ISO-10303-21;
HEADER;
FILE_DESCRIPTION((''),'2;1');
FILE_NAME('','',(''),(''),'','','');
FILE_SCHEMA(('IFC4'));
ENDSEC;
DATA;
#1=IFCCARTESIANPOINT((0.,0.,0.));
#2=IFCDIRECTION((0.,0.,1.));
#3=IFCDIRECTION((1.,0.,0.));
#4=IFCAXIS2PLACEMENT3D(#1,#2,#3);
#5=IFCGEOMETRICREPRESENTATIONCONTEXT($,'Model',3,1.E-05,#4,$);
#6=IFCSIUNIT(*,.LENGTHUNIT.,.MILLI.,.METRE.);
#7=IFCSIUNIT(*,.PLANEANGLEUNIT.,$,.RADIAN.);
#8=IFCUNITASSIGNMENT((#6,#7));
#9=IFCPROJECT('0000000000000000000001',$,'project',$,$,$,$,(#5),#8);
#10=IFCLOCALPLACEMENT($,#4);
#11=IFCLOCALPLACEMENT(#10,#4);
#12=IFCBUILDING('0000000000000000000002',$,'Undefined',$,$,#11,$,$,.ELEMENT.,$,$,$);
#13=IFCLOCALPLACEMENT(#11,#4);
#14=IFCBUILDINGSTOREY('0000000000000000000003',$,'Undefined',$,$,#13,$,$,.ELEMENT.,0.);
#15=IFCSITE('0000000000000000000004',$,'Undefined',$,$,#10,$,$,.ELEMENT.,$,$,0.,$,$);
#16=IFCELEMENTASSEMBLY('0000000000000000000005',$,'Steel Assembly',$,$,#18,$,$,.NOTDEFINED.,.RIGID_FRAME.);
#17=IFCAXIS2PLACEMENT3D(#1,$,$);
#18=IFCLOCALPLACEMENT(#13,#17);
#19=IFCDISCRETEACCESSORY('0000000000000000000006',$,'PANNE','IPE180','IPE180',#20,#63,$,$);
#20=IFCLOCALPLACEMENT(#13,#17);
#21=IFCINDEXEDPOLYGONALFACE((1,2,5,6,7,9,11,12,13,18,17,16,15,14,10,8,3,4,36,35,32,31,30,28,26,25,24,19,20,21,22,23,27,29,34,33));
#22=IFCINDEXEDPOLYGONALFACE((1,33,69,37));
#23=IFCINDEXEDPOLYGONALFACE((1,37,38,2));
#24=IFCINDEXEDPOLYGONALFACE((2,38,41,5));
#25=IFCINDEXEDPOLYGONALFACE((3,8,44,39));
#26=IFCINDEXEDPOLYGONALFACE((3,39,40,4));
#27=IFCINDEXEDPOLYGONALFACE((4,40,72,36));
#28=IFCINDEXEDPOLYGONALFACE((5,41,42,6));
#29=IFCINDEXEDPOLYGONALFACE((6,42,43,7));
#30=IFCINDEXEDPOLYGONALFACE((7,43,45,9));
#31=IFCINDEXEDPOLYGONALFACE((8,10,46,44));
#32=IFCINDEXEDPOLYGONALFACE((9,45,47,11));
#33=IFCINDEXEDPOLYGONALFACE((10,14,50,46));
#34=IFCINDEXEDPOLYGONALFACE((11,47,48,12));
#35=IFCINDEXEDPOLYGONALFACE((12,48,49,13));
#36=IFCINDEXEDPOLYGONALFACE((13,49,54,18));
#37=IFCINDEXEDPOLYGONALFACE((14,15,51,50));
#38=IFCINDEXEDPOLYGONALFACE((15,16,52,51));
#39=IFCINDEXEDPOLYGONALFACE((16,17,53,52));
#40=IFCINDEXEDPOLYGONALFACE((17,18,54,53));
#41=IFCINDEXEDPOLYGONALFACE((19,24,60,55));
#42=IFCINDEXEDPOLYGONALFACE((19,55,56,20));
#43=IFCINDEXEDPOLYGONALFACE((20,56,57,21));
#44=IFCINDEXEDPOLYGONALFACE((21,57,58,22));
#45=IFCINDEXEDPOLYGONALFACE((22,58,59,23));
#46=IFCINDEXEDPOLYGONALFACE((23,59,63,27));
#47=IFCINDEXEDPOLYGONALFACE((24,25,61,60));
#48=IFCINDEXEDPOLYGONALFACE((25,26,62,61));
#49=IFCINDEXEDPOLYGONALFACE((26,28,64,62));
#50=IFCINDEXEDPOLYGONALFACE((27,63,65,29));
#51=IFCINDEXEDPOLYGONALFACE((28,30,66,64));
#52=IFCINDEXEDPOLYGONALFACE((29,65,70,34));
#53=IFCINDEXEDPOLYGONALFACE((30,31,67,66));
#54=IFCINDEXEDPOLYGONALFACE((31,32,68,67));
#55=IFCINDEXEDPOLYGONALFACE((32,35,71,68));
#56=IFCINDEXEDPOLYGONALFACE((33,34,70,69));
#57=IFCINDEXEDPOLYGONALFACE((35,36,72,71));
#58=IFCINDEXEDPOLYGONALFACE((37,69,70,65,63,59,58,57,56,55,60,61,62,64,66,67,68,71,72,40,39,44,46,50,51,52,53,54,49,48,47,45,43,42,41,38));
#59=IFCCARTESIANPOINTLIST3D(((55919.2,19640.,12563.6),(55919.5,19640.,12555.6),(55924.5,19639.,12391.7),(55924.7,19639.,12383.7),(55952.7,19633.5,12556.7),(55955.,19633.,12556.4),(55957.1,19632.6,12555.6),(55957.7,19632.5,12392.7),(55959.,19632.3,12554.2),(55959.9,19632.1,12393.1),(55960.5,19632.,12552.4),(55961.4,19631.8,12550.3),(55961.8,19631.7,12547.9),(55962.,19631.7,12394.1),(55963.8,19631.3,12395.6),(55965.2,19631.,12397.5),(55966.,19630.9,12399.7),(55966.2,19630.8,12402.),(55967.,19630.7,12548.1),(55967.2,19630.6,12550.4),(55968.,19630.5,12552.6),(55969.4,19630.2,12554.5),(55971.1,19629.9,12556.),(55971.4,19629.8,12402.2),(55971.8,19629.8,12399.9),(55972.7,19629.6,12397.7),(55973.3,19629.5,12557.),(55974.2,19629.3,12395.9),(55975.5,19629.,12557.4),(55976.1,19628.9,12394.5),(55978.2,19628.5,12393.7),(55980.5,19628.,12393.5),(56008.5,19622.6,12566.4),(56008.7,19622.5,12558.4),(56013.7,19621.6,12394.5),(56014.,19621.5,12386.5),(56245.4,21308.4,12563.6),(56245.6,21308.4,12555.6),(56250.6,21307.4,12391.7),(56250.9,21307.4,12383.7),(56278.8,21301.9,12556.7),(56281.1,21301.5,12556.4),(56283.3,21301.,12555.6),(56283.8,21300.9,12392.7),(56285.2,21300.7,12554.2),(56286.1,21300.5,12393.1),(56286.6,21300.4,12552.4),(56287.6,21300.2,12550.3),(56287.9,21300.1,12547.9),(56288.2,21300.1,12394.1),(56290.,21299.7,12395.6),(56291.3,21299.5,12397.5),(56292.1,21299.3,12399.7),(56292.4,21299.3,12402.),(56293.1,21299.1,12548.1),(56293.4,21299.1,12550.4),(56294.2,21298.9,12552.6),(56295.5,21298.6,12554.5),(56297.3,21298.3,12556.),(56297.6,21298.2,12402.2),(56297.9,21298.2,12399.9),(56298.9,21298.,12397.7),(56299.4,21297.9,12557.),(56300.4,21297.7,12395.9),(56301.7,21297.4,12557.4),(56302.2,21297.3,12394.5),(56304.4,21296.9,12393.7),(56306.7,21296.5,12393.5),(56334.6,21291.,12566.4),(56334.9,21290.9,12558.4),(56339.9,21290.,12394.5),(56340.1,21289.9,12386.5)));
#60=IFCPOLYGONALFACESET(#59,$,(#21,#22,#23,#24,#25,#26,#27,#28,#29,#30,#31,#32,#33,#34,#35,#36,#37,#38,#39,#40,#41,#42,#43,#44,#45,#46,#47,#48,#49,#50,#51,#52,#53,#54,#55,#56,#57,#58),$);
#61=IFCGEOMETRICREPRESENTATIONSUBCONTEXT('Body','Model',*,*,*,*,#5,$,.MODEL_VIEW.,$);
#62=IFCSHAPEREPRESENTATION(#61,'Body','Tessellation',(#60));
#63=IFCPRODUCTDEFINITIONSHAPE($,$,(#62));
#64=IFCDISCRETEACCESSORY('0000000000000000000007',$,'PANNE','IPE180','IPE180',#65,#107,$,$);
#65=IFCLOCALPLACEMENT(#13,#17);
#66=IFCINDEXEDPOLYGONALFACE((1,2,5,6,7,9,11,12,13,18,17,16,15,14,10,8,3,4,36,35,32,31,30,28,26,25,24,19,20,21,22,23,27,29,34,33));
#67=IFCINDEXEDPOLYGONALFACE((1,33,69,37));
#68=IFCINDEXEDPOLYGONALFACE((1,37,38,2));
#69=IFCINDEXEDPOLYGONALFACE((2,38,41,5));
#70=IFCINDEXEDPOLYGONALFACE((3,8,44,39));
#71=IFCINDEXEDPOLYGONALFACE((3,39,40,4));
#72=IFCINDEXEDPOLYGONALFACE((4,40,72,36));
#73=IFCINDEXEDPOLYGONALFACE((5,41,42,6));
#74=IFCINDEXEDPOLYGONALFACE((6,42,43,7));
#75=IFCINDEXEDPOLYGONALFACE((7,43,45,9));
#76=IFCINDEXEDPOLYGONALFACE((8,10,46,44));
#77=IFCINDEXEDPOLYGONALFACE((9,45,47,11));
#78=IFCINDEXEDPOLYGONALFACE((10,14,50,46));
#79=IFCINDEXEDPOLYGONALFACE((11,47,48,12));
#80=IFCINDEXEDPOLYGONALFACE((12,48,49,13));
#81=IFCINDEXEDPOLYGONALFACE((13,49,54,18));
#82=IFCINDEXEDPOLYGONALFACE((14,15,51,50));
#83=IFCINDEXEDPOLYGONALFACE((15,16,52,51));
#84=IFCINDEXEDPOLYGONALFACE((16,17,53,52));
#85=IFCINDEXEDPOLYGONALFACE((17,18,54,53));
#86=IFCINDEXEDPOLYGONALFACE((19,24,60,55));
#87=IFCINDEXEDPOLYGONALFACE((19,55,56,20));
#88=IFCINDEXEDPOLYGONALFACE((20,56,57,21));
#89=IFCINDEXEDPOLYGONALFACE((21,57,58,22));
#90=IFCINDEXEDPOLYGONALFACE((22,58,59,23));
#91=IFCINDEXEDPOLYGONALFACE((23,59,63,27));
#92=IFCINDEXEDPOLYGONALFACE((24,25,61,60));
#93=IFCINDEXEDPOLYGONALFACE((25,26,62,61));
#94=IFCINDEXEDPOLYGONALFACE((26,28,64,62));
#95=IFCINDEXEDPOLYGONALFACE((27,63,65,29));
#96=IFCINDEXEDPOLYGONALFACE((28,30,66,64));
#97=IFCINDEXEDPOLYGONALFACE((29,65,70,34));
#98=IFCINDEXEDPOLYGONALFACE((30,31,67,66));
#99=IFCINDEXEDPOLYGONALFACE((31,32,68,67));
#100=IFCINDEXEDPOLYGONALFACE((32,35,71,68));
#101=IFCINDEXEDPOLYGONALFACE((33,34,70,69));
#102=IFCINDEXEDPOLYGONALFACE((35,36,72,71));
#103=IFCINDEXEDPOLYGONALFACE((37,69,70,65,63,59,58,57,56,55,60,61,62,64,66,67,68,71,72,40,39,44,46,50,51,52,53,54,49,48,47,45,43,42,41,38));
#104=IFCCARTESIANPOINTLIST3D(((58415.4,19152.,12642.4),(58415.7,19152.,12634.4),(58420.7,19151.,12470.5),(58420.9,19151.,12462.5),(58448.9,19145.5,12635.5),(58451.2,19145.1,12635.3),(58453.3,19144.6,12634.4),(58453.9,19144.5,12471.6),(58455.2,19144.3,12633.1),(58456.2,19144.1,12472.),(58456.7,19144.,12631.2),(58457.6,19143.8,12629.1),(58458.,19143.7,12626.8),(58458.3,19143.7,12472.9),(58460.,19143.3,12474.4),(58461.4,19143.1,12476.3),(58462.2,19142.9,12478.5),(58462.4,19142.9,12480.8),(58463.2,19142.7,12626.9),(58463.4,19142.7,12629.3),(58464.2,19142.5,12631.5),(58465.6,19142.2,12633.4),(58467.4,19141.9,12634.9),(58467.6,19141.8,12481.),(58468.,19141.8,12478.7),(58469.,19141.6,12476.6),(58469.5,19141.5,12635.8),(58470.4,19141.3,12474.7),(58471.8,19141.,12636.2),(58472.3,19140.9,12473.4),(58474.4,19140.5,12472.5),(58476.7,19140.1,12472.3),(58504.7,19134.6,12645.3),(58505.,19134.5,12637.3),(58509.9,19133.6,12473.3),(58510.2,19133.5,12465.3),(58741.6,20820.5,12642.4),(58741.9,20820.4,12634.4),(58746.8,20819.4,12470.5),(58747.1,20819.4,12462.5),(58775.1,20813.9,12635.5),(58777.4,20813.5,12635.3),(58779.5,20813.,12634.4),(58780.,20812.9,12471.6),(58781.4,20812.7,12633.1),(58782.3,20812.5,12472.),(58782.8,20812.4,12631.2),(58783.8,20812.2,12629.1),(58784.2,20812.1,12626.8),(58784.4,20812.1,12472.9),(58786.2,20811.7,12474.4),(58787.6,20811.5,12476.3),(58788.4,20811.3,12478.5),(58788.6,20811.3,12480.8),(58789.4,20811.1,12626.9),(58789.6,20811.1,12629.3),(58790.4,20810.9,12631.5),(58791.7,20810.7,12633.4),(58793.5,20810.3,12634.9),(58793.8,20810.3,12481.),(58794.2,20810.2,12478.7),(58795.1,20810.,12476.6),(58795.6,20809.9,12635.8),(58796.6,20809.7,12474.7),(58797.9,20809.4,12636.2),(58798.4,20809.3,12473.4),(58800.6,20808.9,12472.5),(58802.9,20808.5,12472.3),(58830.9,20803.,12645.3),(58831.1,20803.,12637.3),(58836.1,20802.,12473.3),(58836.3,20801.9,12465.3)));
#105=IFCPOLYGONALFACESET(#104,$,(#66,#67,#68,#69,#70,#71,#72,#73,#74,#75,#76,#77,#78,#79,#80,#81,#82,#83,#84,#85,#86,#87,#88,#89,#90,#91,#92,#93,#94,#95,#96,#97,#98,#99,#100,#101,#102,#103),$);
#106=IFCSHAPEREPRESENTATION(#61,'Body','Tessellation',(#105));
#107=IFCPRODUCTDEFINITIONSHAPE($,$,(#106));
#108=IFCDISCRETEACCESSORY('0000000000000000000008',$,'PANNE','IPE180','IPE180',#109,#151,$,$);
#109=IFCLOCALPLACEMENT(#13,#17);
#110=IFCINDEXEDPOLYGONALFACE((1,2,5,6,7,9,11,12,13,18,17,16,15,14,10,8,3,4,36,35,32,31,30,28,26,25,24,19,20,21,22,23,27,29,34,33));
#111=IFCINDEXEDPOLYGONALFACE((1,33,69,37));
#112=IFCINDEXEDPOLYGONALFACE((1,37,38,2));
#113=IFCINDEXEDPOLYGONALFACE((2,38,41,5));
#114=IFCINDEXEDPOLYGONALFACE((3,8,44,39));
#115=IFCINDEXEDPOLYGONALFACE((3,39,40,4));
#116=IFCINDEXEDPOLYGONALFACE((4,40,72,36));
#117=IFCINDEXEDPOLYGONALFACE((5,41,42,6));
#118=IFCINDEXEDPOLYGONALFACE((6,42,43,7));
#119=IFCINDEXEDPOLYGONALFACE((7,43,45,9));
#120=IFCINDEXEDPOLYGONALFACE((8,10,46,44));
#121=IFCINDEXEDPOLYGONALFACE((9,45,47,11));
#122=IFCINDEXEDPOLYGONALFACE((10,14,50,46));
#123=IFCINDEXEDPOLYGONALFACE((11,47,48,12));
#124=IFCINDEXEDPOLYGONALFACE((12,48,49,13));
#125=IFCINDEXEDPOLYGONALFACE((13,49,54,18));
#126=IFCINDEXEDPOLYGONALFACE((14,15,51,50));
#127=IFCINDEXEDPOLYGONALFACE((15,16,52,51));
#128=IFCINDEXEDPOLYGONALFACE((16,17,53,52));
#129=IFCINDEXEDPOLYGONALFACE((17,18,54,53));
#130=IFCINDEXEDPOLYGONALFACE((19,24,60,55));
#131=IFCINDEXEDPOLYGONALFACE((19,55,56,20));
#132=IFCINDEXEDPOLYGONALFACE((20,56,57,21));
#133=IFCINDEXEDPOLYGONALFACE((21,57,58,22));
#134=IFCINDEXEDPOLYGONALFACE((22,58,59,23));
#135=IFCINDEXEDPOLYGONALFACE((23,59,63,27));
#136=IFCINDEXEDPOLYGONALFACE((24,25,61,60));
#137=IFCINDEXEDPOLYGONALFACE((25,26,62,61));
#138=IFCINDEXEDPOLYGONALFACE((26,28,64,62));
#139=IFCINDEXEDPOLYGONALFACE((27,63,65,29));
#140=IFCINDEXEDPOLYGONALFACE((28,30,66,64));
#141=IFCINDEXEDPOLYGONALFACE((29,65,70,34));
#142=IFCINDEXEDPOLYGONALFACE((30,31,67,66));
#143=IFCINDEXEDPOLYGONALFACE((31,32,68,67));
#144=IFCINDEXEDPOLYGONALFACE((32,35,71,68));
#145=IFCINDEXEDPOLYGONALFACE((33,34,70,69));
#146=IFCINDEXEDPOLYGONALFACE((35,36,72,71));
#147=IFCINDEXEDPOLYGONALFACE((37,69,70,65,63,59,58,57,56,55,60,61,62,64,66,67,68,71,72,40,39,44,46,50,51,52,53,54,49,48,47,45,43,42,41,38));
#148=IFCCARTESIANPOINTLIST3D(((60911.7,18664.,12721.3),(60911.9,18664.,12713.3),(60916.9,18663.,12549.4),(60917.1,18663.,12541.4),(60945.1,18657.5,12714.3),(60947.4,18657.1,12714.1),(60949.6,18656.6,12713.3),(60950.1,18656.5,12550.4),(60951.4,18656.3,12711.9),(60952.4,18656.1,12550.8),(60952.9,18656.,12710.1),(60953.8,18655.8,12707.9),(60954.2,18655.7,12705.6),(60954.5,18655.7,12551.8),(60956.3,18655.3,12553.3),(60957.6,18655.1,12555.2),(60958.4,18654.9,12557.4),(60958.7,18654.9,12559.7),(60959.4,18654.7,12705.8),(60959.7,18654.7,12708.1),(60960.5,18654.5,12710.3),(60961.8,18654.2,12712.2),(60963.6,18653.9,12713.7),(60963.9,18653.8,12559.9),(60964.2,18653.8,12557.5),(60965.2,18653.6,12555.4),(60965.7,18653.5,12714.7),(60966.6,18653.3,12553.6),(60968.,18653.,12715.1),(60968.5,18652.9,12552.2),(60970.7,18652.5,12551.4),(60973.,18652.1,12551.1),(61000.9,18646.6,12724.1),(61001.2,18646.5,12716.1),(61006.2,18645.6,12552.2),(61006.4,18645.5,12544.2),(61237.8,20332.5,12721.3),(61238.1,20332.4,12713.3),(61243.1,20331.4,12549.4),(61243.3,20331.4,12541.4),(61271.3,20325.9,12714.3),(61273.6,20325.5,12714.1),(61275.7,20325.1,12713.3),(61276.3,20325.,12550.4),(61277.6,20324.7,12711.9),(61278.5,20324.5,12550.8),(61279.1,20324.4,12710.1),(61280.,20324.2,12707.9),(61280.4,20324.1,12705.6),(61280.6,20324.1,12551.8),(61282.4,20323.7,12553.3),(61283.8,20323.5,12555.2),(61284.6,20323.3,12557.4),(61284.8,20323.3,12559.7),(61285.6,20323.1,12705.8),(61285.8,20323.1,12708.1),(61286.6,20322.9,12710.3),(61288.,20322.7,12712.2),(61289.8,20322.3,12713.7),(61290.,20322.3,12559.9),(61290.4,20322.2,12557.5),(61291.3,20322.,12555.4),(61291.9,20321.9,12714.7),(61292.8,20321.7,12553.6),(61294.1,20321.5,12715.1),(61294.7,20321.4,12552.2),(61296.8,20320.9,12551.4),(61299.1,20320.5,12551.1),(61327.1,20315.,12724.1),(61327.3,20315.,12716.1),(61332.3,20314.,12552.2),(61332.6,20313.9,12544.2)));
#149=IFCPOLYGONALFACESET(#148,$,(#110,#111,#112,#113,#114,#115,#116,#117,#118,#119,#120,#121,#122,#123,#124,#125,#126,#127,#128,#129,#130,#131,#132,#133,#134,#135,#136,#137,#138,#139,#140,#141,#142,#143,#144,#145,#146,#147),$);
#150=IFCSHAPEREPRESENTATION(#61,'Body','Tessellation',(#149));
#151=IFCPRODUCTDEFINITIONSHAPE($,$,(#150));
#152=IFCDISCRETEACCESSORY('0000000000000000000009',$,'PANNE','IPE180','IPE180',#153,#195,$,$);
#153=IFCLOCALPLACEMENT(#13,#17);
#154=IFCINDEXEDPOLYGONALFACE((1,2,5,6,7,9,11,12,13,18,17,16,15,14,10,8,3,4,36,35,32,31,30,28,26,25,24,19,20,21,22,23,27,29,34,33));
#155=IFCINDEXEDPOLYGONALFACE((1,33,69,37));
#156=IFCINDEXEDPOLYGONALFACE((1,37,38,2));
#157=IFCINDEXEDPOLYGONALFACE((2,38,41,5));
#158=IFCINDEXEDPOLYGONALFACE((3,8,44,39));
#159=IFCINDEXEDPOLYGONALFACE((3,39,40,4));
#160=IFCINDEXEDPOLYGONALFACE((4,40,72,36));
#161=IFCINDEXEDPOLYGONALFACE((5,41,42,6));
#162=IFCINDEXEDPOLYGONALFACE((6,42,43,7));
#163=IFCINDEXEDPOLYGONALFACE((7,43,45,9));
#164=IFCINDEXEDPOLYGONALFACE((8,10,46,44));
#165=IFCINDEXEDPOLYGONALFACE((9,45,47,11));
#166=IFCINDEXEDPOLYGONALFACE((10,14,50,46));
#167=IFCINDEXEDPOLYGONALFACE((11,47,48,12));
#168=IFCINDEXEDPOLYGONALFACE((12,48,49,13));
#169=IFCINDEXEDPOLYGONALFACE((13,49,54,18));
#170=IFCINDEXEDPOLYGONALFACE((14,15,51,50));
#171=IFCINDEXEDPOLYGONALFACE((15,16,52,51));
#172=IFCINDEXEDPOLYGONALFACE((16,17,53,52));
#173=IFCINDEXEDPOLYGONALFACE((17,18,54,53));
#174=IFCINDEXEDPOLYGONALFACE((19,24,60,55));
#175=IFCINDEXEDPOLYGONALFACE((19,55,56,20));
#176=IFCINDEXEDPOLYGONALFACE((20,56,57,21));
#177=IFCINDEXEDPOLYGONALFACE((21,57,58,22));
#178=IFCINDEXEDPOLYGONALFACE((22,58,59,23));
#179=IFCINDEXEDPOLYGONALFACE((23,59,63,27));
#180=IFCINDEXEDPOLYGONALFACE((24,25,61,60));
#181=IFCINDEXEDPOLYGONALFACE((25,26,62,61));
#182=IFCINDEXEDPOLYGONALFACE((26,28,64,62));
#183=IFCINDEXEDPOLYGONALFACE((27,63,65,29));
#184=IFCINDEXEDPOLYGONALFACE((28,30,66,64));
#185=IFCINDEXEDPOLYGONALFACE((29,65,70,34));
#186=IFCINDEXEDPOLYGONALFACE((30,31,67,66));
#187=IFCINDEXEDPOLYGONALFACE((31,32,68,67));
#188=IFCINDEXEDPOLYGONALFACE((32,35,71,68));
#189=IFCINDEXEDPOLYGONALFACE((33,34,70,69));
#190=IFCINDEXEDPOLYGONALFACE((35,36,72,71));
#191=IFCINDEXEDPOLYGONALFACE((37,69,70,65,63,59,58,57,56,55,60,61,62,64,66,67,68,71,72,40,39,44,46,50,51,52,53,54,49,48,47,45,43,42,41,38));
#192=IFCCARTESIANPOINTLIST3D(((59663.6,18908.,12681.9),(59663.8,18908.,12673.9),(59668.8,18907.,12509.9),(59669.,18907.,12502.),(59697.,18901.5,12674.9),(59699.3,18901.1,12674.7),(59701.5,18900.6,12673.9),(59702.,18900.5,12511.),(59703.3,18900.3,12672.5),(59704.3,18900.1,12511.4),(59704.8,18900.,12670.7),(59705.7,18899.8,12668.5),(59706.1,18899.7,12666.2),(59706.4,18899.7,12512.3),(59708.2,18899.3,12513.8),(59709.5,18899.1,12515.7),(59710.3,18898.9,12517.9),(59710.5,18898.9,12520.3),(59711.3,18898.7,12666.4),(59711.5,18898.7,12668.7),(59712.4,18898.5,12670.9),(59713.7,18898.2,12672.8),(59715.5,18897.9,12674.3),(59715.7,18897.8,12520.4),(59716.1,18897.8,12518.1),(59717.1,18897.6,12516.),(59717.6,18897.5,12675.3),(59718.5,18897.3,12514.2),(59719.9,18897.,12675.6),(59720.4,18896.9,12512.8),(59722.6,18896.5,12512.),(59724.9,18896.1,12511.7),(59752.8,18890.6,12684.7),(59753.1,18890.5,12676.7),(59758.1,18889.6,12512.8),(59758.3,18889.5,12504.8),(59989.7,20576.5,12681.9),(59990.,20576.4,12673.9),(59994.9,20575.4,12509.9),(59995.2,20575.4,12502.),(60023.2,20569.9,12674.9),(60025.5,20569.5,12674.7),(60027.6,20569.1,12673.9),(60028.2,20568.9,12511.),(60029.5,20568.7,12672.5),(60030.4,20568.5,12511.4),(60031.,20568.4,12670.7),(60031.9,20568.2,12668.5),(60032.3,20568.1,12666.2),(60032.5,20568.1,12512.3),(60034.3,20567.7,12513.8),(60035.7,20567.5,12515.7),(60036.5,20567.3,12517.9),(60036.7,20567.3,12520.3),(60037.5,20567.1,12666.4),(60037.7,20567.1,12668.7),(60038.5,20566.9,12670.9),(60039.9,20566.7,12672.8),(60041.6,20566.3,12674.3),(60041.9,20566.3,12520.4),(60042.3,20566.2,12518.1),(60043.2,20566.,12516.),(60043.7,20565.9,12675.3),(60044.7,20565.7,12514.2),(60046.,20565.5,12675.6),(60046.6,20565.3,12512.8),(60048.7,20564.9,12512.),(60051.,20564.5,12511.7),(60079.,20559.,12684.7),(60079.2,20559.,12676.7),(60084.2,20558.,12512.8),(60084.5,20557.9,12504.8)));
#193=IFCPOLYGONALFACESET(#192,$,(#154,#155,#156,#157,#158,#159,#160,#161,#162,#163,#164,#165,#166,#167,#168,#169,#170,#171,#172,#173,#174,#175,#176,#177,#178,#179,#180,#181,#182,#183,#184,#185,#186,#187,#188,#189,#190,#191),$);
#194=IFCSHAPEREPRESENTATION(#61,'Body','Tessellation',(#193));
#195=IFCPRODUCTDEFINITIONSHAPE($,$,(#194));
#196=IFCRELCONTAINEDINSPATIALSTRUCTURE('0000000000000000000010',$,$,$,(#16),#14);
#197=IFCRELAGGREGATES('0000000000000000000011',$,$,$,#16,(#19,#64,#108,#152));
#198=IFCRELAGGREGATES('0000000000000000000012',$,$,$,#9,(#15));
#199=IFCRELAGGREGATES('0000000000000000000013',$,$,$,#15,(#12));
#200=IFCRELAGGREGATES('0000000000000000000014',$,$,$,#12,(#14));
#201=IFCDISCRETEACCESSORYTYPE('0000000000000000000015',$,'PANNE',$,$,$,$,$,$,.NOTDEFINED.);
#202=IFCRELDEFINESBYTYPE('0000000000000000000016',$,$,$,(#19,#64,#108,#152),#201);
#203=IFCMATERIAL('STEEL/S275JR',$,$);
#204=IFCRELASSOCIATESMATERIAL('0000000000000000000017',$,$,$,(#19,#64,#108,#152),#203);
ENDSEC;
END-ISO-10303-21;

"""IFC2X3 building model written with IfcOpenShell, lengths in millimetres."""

from ifc_helpers import new_model, si_unit, frame, origin_with_axes, origin_2d_with_axis, place, context, subcontext, project, spatial, i_section, extrude, material, type_object, element, aggregate, save


model = new_model("IFC2X3")

# Units and contexts
model_context = context("Model", 3, precision=1e-05, world=origin_with_axes())
body_context = subcontext(model_context, "Body", "Model", "MODEL_VIEW")
ifc_project = project(units=[si_unit("LENGTHUNIT", "METRE", prefix="MILLI"), si_unit("PLANEANGLEUNIT", "RADIAN")], contexts=[model_context])

# Site, building, storey
site_placement = place(None, origin_with_axes())
site = spatial("IfcSite", under=ifc_project, at=site_placement, Name="Undefined", CompositionType="ELEMENT", RefElevation=0.0)
building_placement = place(site_placement, origin_with_axes())
building = spatial("IfcBuilding", under=site, at=building_placement, Name="Undefined", CompositionType="ELEMENT")
storey_placement = place(building_placement, origin_with_axes())
storey = spatial("IfcBuildingStorey", under=building, at=storey_placement, Name="Undefined", CompositionType="ELEMENT", Elevation=0.0)

# Shared definitions
ifc_material_1 = material(Name="STEEL/S275JR")

# Element assembly, discrete accessories
assembly_1_placement = place(storey_placement, origin_with_axes())
assembly_1 = element("IfcElementAssembly", 1, at=assembly_1_placement, inside=storey, Name="Steel Assembly", AssemblyPlace="NOTDEFINED", PredefinedType="RIGID_FRAME")
discrete_accessory_type_1 = type_object("IfcDiscreteAccessoryType", Name="PANNE")
discrete_accessory_1_placement = place(assembly_1_placement, frame((55966.6, 19630.8, 12475.1), z_axis=(-0.030408, 0.005945, 0.99952), x_axis=(0.191859, 0.981422, 0.0)))
discrete_accessory_1 = element("IfcDiscreteAccessory", 2, at=discrete_accessory_1_placement, type_object=discrete_accessory_type_1, material=ifc_material_1, Name="PANNE", Description="IPE180", ObjectType="IPE180", context=body_context, shape_type="SweptSolid", body=[
    extrude(i_section(OverallWidth=91.0, OverallDepth=180.0, WebThickness=5.3, FlangeThickness=8.0, FilletRadius=9.0, at=origin_2d_with_axis()), frame((1700.0, 0.0, 0.0), z_axis=(-1.0, 0.0, 0.0), x_axis=(0.0, -1.0, 0.0)), (0.0, 0.0, 1.0), 1700.0),
])
discrete_accessory_2_placement = place(assembly_1_placement, frame((58462.8, 19142.8, 12553.9), z_axis=(-0.030408, 0.005945, 0.99952), x_axis=(0.191859, 0.981422, 0.0)))
discrete_accessory_2 = element("IfcDiscreteAccessory", 3, at=discrete_accessory_2_placement, type_object=discrete_accessory_type_1, material=ifc_material_1, Name="PANNE", Description="IPE180", ObjectType="IPE180", context=body_context, shape_type="SweptSolid", body=[
    extrude(i_section(OverallWidth=91.0, OverallDepth=180.0, WebThickness=5.3, FlangeThickness=8.0, FilletRadius=9.0, at=origin_2d_with_axis()), frame((1700.0, 0.0, 0.0), z_axis=(-1.0, 0.0, 0.0), x_axis=(0.0, -1.0, 0.0)), (0.0, 0.0, 1.0), 1700.0),
])
discrete_accessory_3_placement = place(assembly_1_placement, frame((60959.0, 18654.8, 12632.7), z_axis=(-0.030408, 0.005945, 0.99952), x_axis=(0.191859, 0.981422, 0.0)))
discrete_accessory_3 = element("IfcDiscreteAccessory", 4, at=discrete_accessory_3_placement, type_object=discrete_accessory_type_1, material=ifc_material_1, Name="PANNE", Description="IPE180", ObjectType="IPE180", context=body_context, shape_type="SweptSolid", body=[
    extrude(i_section(OverallWidth=91.0, OverallDepth=180.0, WebThickness=5.3, FlangeThickness=8.0, FilletRadius=9.0, at=origin_2d_with_axis()), frame((1700.0, 0.0, 0.0), z_axis=(-1.0, 0.0, 0.0), x_axis=(0.0, -1.0, 0.0)), (0.0, 0.0, 1.0), 1700.0),
])
discrete_accessory_4_placement = place(assembly_1_placement, frame((59710.9, 18898.8, 12593.3), z_axis=(-0.030408, 0.005945, 0.99952), x_axis=(0.191859, 0.981422, 0.0)))
discrete_accessory_4 = element("IfcDiscreteAccessory", 5, at=discrete_accessory_4_placement, type_object=discrete_accessory_type_1, material=ifc_material_1, Name="PANNE", Description="IPE180", ObjectType="IPE180", context=body_context, shape_type="SweptSolid", body=[
    extrude(i_section(OverallWidth=91.0, OverallDepth=180.0, WebThickness=5.3, FlangeThickness=8.0, FilletRadius=9.0, at=origin_2d_with_axis()), frame((1700.0, 0.0, 0.0), z_axis=(-1.0, 0.0, 0.0), x_axis=(0.0, -1.0, 0.0)), (0.0, 0.0, 1.0), 1700.0),
])
aggregate(assembly_1, [discrete_accessory_1, discrete_accessory_2, discrete_accessory_3, discrete_accessory_4])

save(model, "model.ifc")
